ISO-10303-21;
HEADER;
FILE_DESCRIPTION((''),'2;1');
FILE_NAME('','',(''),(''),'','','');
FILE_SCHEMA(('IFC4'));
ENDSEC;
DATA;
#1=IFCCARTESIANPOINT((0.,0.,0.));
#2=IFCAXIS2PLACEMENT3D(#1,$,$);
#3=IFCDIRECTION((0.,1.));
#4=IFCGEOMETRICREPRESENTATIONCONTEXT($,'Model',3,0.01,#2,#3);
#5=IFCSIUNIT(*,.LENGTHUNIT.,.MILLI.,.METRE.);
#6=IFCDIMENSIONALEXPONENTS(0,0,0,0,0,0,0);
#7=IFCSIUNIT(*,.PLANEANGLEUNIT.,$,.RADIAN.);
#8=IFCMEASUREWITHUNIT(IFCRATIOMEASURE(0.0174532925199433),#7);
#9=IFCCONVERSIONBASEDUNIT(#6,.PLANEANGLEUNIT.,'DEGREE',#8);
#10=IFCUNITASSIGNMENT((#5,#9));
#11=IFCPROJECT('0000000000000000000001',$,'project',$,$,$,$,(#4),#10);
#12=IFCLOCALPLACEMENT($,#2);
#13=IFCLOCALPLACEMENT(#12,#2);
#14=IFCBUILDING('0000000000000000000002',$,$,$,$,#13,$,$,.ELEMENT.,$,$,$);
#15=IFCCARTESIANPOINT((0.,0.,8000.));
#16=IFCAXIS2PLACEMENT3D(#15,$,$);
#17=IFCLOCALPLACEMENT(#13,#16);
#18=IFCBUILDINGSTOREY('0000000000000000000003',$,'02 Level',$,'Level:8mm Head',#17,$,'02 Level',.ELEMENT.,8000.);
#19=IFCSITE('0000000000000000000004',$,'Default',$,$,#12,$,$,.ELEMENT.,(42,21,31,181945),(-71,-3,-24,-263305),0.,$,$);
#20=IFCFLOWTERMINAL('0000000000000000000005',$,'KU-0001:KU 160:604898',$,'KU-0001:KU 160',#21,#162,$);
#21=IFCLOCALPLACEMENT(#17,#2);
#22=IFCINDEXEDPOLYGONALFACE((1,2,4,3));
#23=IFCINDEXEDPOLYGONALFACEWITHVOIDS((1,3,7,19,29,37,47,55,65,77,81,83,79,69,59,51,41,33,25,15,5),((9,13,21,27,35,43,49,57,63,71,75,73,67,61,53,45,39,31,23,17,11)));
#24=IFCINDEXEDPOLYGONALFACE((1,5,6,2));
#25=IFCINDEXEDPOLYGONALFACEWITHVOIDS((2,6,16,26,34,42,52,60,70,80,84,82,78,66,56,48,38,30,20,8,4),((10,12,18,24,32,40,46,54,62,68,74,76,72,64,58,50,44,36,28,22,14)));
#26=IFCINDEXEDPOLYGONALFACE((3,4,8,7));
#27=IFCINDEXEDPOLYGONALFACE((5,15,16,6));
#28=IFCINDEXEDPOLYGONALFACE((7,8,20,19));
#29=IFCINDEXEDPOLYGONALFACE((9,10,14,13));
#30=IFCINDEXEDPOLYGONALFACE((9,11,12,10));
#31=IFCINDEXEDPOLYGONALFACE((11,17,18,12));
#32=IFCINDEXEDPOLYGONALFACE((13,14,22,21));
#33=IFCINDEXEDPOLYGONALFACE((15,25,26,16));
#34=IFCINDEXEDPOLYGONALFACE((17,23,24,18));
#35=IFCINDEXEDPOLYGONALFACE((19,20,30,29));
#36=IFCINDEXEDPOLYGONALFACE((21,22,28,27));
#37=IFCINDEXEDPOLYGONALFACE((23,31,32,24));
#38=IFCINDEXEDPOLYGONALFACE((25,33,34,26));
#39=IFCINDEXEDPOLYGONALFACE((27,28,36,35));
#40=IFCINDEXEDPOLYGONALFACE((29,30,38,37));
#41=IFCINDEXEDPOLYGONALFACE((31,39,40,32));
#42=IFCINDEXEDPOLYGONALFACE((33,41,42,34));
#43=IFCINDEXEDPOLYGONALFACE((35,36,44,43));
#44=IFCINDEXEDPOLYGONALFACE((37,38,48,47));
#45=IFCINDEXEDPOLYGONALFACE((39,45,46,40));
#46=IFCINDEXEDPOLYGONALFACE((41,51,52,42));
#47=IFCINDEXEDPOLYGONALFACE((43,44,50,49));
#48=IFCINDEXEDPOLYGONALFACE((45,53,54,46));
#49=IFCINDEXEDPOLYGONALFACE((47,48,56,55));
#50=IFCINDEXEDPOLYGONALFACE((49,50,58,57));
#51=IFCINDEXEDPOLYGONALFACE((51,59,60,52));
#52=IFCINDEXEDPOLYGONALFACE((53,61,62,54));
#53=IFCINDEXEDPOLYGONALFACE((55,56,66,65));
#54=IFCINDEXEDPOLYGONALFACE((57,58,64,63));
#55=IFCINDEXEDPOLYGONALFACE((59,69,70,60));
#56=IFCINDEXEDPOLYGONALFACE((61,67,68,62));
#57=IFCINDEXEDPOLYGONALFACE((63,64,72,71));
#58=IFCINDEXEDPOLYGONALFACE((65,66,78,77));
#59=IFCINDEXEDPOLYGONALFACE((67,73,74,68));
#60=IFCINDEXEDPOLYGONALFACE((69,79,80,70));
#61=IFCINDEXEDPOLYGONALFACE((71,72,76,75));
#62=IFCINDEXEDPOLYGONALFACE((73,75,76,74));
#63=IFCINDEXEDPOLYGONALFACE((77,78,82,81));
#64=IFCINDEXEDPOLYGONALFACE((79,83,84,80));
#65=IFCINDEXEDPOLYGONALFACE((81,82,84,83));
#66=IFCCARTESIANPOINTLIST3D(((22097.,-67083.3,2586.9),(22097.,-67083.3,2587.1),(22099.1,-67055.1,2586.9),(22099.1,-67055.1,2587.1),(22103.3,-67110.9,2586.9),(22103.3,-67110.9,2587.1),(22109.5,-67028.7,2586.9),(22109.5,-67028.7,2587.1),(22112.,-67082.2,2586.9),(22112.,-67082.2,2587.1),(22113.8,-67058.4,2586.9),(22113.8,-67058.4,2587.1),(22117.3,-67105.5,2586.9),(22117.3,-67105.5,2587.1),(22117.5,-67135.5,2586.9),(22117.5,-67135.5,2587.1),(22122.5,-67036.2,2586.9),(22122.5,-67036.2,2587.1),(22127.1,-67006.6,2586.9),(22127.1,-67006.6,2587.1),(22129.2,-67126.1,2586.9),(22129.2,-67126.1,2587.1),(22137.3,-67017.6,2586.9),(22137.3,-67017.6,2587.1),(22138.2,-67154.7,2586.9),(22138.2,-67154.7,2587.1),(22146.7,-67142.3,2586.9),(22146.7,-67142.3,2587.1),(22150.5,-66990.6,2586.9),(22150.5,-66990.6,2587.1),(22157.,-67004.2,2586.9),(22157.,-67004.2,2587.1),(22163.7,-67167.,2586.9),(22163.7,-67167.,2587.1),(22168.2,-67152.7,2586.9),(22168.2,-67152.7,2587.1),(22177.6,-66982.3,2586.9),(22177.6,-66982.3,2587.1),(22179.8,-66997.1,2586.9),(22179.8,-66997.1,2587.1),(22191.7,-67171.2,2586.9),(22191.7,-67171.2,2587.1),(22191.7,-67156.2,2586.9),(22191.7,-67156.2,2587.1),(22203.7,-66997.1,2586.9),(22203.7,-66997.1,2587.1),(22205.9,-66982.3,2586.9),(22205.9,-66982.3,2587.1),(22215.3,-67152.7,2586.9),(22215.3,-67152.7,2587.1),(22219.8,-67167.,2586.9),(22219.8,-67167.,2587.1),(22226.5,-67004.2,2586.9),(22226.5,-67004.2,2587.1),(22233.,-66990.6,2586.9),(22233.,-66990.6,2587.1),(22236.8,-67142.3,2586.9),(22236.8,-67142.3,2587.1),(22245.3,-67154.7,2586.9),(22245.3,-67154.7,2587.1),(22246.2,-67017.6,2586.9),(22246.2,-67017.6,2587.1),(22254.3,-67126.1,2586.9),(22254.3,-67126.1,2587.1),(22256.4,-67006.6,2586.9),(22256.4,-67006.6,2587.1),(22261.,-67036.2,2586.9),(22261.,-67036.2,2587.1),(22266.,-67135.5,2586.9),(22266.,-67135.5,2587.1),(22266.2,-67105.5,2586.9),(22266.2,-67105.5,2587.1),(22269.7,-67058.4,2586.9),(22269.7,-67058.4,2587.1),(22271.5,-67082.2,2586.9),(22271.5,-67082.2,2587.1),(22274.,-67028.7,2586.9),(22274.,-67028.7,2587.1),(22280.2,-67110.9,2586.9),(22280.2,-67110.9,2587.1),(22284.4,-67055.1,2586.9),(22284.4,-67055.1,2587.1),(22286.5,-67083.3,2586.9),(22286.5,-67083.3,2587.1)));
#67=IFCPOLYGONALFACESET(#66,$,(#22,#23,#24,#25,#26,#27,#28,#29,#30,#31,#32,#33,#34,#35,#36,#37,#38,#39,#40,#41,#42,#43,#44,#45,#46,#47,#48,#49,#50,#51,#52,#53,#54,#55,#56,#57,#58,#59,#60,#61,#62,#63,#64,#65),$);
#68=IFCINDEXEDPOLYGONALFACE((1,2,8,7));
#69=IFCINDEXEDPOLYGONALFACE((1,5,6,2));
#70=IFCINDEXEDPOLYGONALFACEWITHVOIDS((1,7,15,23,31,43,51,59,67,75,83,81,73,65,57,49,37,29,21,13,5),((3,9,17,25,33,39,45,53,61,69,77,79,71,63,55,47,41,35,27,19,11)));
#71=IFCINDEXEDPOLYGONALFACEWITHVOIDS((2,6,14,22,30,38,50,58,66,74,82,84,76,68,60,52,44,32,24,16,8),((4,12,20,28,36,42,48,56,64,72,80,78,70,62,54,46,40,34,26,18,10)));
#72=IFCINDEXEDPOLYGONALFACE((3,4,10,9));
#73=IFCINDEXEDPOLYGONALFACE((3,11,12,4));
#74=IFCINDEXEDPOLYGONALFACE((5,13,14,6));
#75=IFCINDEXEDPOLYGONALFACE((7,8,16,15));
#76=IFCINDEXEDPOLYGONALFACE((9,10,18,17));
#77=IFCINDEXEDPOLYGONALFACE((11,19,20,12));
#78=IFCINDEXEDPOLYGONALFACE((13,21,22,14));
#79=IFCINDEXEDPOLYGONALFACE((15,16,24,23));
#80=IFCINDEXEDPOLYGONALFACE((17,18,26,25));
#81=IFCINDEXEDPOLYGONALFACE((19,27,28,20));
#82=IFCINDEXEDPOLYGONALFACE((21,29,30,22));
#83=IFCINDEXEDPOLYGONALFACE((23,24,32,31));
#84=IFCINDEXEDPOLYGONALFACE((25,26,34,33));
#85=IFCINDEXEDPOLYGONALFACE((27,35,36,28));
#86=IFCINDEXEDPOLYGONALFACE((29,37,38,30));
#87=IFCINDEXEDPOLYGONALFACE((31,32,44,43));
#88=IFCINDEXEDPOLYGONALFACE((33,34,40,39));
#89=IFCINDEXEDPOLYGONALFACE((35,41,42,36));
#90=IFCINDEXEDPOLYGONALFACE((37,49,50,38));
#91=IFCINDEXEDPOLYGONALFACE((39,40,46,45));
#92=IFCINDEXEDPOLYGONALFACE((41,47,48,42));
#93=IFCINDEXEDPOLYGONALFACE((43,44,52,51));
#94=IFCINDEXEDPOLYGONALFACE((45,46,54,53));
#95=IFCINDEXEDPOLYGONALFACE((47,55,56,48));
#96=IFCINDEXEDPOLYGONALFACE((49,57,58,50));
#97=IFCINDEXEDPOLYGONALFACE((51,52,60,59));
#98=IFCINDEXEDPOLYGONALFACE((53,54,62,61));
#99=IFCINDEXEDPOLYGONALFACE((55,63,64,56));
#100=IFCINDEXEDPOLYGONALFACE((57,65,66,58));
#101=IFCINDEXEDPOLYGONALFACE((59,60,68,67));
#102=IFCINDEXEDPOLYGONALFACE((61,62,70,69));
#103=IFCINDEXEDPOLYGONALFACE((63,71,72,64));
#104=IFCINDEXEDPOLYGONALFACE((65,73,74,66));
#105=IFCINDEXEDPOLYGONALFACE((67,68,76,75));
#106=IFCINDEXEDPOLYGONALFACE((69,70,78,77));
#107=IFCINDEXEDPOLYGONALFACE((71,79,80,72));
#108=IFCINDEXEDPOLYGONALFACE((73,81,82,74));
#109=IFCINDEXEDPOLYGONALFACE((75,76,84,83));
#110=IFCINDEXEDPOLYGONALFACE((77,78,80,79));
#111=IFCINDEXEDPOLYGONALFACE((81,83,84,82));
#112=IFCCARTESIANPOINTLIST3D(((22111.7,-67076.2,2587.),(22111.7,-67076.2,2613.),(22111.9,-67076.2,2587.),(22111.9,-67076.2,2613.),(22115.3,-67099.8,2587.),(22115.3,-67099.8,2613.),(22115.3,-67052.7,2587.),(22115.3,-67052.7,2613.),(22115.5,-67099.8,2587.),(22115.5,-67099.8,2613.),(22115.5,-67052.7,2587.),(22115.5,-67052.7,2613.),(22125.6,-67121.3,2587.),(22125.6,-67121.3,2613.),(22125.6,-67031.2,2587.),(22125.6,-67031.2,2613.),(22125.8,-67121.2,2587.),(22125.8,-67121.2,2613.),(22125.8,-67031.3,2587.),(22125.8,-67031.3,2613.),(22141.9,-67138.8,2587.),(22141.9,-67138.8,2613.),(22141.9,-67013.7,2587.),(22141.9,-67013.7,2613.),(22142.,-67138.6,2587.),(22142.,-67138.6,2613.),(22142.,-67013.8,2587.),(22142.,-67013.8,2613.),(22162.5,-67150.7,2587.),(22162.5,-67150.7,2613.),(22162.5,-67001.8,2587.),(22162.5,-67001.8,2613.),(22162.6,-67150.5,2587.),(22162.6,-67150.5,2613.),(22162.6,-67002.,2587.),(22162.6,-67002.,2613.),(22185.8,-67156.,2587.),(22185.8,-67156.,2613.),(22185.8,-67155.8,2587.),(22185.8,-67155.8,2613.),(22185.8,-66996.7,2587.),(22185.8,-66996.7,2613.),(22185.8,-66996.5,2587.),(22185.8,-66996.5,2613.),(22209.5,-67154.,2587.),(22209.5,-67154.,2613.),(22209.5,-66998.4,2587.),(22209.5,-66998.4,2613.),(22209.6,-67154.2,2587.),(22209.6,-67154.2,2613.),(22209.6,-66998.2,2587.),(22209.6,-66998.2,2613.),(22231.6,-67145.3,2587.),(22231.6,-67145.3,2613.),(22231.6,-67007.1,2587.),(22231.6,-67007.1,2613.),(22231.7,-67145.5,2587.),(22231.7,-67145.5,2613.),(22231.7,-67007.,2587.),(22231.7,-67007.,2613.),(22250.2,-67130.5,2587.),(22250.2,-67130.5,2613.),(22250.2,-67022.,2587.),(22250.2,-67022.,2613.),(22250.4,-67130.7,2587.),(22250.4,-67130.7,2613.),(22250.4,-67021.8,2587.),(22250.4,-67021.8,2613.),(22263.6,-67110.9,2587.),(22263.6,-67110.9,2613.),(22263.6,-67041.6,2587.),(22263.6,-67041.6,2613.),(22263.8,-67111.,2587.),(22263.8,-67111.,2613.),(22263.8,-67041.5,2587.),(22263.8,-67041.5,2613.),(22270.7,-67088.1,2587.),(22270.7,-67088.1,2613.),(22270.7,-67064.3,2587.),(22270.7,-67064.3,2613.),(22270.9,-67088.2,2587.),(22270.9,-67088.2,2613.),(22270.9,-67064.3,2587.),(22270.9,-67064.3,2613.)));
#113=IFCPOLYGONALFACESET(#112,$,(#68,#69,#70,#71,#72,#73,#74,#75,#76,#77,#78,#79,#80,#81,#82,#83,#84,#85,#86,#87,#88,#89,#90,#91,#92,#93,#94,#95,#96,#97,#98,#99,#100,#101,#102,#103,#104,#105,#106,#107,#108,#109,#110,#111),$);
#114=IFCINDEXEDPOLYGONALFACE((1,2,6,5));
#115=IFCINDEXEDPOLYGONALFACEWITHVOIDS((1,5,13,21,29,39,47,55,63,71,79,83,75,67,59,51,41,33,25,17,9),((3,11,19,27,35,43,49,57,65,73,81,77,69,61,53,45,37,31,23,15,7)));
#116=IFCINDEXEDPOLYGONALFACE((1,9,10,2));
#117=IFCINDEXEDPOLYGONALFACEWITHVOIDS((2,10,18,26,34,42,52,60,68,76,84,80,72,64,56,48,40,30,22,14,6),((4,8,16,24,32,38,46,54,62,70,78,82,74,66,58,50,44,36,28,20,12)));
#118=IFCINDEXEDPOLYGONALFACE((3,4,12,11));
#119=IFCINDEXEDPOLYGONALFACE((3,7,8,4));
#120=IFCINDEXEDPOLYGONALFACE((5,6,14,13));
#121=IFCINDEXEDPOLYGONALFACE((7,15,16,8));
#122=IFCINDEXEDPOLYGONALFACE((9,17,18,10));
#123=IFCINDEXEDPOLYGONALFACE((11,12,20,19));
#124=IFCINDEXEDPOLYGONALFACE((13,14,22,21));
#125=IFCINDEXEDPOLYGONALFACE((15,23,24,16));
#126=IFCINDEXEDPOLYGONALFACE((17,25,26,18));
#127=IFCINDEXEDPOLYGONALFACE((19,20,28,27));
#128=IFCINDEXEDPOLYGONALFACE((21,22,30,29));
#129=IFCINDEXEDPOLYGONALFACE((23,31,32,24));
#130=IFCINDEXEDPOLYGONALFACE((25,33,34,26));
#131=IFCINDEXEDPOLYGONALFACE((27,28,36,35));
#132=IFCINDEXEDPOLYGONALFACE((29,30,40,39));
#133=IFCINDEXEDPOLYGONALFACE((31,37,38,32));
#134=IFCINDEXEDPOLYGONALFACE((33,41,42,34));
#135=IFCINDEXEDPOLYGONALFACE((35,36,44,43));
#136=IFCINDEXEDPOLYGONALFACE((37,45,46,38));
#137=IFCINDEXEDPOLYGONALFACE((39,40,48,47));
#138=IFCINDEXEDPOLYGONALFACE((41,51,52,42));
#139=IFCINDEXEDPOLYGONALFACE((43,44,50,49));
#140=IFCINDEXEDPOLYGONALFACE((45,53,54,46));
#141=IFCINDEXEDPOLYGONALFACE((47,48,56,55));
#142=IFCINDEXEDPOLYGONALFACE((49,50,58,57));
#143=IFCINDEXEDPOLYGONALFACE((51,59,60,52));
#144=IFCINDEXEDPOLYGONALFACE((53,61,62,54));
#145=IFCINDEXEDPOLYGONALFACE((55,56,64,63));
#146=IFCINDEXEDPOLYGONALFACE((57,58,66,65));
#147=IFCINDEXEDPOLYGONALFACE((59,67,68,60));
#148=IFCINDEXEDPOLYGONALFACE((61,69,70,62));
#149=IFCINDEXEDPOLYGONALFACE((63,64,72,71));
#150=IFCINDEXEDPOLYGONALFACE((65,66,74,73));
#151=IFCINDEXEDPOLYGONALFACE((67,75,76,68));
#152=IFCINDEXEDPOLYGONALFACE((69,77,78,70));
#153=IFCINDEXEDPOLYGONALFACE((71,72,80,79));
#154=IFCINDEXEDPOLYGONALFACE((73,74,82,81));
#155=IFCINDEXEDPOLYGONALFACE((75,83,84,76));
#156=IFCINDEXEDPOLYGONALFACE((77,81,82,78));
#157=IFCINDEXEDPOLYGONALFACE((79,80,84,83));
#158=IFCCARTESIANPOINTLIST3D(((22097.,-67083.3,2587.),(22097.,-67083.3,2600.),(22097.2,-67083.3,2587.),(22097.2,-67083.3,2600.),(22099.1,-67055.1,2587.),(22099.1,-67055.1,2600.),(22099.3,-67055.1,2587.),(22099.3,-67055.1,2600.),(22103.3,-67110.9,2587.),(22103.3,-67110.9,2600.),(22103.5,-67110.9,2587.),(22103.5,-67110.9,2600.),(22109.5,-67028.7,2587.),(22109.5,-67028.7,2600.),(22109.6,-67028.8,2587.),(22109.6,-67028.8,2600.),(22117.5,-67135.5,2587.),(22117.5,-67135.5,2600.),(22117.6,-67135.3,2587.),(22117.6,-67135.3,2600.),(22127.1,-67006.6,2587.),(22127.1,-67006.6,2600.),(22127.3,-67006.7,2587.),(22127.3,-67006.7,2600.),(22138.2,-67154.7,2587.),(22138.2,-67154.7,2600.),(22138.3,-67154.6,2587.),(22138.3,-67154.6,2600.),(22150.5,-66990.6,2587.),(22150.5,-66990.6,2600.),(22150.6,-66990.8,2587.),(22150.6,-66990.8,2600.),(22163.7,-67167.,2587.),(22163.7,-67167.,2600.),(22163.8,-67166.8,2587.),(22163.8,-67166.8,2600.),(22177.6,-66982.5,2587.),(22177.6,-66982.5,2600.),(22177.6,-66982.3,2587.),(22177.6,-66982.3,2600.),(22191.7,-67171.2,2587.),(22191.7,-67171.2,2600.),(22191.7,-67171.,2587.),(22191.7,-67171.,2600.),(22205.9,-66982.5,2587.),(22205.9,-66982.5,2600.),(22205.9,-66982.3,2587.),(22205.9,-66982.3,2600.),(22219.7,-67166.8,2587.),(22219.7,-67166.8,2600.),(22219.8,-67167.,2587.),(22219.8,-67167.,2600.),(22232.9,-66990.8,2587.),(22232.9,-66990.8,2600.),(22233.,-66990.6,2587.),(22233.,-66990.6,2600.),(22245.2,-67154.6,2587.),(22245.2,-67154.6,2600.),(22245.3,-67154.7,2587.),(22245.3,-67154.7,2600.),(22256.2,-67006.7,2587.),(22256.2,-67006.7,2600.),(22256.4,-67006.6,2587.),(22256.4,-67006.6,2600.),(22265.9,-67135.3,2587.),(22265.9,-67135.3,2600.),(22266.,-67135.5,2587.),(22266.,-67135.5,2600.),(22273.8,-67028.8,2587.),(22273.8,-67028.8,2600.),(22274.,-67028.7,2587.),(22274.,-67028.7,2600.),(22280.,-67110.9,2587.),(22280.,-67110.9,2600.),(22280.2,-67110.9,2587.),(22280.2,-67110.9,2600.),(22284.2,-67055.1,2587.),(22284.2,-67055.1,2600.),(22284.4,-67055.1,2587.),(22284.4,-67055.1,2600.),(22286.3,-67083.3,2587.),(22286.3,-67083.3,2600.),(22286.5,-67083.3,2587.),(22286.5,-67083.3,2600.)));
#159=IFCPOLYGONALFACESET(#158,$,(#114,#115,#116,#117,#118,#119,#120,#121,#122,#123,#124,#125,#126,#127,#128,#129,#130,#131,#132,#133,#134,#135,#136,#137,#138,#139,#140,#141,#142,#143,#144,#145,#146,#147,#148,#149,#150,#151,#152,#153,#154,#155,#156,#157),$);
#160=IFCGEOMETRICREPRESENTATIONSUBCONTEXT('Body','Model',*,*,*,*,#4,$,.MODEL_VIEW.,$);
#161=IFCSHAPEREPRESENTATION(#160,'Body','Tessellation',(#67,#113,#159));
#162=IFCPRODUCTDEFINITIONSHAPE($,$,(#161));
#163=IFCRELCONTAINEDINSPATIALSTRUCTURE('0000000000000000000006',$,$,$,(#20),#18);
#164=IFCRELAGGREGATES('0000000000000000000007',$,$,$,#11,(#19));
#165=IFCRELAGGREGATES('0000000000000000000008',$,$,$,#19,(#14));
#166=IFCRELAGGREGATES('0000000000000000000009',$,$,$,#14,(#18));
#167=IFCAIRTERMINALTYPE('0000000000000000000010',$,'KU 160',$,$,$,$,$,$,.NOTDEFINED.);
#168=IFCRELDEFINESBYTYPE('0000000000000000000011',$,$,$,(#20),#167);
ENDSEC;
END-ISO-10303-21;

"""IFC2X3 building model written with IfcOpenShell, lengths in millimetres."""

from ifc_helpers import new_model, entity, si_unit, converted_unit, direction, frame, frame_2d, origin, place, context, subcontext, project, spatial, hollow_circle, extrude, source, transform, mapped, type_object, type_shapes, element, save


model = new_model("IFC2X3")

# Units and contexts
model_context = context("Model", 3, precision=0.01, world=origin(), true_north=direction((0.0, 1.0)))
body_context = subcontext(model_context, "Body", "Model", "MODEL_VIEW")
ifc_project = project(units=[si_unit("LENGTHUNIT", "METRE", prefix="MILLI"), converted_unit("PLANEANGLEUNIT", "DEGREE", entity("IfcRatioMeasure", 0.0174532925199433), si_unit("PLANEANGLEUNIT", "RADIAN"), dimensions=[0, 0, 0, 0, 0, 0, 0])], contexts=[model_context])

# Site, building, storey
site_placement = place(None, origin())
site = spatial("IfcSite", under=ifc_project, at=site_placement, Name="Default", CompositionType="ELEMENT", RefLatitude=(42, 21, 31, 181945), RefLongitude=(-71, -3, -24, -263305), RefElevation=0.0)
building_placement = place(site_placement, origin())
building = spatial("IfcBuilding", under=site, at=building_placement, CompositionType="ELEMENT")
storey_placement = place(building_placement, frame((0.0, 0.0, 8000.0)))
storey = spatial("IfcBuildingStorey", under=building, at=storey_placement, Name="02 Level", ObjectType="Level:8mm Head", LongName="02 Level", CompositionType="ELEMENT", Elevation=8000.0)

# Flow terminal
air_terminal_type_1 = type_object("IfcAirTerminalType", Name="KU 160", PredefinedType="NOTDEFINED")
shared_shape_1 = source(origin(), body_context, "Body", "SweptSolid", [
    extrude(hollow_circle(Radius=95.0, WallThickness=15.0, at=frame_2d((0.0, 0.0), x_axis=(1.0, 0.0))), frame((12.9, 0.0, 0.0), z_axis=(1.0, 0.0, 0.0), x_axis=(0.0, -1.0, 0.0)), (0.0, 0.0, 1.0), 0.2),
    extrude(hollow_circle(Radius=80.0, WallThickness=0.2, at=frame_2d((0.0, 0.0), x_axis=(1.0, 0.0))), frame((-13.0, 0.0, 0.0), z_axis=(1.0, 0.0, 0.0), x_axis=(0.0, 0.0, -1.0)), (0.0, 0.0, 1.0), 26.0),
    extrude(hollow_circle(Radius=95.0, WallThickness=0.2, at=frame_2d((0.0, 0.0), x_axis=(1.0, 0.0))), frame((0.0, 0.0, 0.0), z_axis=(1.0, 0.0, 0.0), x_axis=(0.0, -1.0, 0.0)), (0.0, 0.0, 1.0), 13.0),
])
type_shapes(air_terminal_type_1, [shared_shape_1])
for number, where, z_axis, x_axis, name in (
    (1, (22191.7, -67076.2, 2600.0), (1.0, 0.0, 0.0), (0.0, 0.0, -1.0), "KU-0001:KU 160:604898"),
):
    element("IfcFlowTerminal", number, at=place(storey_placement, frame(where, z_axis=z_axis, x_axis=x_axis)), inside=storey, type_object=air_terminal_type_1, Name=name, ObjectType="KU-0001:KU 160", context=body_context, shape_type="MappedRepresentation", body=[
        mapped(shared_shape_1, transform((0.0, 0.0, 0.0), scale=1.0)),
    ])

save(model, "model.ifc")
